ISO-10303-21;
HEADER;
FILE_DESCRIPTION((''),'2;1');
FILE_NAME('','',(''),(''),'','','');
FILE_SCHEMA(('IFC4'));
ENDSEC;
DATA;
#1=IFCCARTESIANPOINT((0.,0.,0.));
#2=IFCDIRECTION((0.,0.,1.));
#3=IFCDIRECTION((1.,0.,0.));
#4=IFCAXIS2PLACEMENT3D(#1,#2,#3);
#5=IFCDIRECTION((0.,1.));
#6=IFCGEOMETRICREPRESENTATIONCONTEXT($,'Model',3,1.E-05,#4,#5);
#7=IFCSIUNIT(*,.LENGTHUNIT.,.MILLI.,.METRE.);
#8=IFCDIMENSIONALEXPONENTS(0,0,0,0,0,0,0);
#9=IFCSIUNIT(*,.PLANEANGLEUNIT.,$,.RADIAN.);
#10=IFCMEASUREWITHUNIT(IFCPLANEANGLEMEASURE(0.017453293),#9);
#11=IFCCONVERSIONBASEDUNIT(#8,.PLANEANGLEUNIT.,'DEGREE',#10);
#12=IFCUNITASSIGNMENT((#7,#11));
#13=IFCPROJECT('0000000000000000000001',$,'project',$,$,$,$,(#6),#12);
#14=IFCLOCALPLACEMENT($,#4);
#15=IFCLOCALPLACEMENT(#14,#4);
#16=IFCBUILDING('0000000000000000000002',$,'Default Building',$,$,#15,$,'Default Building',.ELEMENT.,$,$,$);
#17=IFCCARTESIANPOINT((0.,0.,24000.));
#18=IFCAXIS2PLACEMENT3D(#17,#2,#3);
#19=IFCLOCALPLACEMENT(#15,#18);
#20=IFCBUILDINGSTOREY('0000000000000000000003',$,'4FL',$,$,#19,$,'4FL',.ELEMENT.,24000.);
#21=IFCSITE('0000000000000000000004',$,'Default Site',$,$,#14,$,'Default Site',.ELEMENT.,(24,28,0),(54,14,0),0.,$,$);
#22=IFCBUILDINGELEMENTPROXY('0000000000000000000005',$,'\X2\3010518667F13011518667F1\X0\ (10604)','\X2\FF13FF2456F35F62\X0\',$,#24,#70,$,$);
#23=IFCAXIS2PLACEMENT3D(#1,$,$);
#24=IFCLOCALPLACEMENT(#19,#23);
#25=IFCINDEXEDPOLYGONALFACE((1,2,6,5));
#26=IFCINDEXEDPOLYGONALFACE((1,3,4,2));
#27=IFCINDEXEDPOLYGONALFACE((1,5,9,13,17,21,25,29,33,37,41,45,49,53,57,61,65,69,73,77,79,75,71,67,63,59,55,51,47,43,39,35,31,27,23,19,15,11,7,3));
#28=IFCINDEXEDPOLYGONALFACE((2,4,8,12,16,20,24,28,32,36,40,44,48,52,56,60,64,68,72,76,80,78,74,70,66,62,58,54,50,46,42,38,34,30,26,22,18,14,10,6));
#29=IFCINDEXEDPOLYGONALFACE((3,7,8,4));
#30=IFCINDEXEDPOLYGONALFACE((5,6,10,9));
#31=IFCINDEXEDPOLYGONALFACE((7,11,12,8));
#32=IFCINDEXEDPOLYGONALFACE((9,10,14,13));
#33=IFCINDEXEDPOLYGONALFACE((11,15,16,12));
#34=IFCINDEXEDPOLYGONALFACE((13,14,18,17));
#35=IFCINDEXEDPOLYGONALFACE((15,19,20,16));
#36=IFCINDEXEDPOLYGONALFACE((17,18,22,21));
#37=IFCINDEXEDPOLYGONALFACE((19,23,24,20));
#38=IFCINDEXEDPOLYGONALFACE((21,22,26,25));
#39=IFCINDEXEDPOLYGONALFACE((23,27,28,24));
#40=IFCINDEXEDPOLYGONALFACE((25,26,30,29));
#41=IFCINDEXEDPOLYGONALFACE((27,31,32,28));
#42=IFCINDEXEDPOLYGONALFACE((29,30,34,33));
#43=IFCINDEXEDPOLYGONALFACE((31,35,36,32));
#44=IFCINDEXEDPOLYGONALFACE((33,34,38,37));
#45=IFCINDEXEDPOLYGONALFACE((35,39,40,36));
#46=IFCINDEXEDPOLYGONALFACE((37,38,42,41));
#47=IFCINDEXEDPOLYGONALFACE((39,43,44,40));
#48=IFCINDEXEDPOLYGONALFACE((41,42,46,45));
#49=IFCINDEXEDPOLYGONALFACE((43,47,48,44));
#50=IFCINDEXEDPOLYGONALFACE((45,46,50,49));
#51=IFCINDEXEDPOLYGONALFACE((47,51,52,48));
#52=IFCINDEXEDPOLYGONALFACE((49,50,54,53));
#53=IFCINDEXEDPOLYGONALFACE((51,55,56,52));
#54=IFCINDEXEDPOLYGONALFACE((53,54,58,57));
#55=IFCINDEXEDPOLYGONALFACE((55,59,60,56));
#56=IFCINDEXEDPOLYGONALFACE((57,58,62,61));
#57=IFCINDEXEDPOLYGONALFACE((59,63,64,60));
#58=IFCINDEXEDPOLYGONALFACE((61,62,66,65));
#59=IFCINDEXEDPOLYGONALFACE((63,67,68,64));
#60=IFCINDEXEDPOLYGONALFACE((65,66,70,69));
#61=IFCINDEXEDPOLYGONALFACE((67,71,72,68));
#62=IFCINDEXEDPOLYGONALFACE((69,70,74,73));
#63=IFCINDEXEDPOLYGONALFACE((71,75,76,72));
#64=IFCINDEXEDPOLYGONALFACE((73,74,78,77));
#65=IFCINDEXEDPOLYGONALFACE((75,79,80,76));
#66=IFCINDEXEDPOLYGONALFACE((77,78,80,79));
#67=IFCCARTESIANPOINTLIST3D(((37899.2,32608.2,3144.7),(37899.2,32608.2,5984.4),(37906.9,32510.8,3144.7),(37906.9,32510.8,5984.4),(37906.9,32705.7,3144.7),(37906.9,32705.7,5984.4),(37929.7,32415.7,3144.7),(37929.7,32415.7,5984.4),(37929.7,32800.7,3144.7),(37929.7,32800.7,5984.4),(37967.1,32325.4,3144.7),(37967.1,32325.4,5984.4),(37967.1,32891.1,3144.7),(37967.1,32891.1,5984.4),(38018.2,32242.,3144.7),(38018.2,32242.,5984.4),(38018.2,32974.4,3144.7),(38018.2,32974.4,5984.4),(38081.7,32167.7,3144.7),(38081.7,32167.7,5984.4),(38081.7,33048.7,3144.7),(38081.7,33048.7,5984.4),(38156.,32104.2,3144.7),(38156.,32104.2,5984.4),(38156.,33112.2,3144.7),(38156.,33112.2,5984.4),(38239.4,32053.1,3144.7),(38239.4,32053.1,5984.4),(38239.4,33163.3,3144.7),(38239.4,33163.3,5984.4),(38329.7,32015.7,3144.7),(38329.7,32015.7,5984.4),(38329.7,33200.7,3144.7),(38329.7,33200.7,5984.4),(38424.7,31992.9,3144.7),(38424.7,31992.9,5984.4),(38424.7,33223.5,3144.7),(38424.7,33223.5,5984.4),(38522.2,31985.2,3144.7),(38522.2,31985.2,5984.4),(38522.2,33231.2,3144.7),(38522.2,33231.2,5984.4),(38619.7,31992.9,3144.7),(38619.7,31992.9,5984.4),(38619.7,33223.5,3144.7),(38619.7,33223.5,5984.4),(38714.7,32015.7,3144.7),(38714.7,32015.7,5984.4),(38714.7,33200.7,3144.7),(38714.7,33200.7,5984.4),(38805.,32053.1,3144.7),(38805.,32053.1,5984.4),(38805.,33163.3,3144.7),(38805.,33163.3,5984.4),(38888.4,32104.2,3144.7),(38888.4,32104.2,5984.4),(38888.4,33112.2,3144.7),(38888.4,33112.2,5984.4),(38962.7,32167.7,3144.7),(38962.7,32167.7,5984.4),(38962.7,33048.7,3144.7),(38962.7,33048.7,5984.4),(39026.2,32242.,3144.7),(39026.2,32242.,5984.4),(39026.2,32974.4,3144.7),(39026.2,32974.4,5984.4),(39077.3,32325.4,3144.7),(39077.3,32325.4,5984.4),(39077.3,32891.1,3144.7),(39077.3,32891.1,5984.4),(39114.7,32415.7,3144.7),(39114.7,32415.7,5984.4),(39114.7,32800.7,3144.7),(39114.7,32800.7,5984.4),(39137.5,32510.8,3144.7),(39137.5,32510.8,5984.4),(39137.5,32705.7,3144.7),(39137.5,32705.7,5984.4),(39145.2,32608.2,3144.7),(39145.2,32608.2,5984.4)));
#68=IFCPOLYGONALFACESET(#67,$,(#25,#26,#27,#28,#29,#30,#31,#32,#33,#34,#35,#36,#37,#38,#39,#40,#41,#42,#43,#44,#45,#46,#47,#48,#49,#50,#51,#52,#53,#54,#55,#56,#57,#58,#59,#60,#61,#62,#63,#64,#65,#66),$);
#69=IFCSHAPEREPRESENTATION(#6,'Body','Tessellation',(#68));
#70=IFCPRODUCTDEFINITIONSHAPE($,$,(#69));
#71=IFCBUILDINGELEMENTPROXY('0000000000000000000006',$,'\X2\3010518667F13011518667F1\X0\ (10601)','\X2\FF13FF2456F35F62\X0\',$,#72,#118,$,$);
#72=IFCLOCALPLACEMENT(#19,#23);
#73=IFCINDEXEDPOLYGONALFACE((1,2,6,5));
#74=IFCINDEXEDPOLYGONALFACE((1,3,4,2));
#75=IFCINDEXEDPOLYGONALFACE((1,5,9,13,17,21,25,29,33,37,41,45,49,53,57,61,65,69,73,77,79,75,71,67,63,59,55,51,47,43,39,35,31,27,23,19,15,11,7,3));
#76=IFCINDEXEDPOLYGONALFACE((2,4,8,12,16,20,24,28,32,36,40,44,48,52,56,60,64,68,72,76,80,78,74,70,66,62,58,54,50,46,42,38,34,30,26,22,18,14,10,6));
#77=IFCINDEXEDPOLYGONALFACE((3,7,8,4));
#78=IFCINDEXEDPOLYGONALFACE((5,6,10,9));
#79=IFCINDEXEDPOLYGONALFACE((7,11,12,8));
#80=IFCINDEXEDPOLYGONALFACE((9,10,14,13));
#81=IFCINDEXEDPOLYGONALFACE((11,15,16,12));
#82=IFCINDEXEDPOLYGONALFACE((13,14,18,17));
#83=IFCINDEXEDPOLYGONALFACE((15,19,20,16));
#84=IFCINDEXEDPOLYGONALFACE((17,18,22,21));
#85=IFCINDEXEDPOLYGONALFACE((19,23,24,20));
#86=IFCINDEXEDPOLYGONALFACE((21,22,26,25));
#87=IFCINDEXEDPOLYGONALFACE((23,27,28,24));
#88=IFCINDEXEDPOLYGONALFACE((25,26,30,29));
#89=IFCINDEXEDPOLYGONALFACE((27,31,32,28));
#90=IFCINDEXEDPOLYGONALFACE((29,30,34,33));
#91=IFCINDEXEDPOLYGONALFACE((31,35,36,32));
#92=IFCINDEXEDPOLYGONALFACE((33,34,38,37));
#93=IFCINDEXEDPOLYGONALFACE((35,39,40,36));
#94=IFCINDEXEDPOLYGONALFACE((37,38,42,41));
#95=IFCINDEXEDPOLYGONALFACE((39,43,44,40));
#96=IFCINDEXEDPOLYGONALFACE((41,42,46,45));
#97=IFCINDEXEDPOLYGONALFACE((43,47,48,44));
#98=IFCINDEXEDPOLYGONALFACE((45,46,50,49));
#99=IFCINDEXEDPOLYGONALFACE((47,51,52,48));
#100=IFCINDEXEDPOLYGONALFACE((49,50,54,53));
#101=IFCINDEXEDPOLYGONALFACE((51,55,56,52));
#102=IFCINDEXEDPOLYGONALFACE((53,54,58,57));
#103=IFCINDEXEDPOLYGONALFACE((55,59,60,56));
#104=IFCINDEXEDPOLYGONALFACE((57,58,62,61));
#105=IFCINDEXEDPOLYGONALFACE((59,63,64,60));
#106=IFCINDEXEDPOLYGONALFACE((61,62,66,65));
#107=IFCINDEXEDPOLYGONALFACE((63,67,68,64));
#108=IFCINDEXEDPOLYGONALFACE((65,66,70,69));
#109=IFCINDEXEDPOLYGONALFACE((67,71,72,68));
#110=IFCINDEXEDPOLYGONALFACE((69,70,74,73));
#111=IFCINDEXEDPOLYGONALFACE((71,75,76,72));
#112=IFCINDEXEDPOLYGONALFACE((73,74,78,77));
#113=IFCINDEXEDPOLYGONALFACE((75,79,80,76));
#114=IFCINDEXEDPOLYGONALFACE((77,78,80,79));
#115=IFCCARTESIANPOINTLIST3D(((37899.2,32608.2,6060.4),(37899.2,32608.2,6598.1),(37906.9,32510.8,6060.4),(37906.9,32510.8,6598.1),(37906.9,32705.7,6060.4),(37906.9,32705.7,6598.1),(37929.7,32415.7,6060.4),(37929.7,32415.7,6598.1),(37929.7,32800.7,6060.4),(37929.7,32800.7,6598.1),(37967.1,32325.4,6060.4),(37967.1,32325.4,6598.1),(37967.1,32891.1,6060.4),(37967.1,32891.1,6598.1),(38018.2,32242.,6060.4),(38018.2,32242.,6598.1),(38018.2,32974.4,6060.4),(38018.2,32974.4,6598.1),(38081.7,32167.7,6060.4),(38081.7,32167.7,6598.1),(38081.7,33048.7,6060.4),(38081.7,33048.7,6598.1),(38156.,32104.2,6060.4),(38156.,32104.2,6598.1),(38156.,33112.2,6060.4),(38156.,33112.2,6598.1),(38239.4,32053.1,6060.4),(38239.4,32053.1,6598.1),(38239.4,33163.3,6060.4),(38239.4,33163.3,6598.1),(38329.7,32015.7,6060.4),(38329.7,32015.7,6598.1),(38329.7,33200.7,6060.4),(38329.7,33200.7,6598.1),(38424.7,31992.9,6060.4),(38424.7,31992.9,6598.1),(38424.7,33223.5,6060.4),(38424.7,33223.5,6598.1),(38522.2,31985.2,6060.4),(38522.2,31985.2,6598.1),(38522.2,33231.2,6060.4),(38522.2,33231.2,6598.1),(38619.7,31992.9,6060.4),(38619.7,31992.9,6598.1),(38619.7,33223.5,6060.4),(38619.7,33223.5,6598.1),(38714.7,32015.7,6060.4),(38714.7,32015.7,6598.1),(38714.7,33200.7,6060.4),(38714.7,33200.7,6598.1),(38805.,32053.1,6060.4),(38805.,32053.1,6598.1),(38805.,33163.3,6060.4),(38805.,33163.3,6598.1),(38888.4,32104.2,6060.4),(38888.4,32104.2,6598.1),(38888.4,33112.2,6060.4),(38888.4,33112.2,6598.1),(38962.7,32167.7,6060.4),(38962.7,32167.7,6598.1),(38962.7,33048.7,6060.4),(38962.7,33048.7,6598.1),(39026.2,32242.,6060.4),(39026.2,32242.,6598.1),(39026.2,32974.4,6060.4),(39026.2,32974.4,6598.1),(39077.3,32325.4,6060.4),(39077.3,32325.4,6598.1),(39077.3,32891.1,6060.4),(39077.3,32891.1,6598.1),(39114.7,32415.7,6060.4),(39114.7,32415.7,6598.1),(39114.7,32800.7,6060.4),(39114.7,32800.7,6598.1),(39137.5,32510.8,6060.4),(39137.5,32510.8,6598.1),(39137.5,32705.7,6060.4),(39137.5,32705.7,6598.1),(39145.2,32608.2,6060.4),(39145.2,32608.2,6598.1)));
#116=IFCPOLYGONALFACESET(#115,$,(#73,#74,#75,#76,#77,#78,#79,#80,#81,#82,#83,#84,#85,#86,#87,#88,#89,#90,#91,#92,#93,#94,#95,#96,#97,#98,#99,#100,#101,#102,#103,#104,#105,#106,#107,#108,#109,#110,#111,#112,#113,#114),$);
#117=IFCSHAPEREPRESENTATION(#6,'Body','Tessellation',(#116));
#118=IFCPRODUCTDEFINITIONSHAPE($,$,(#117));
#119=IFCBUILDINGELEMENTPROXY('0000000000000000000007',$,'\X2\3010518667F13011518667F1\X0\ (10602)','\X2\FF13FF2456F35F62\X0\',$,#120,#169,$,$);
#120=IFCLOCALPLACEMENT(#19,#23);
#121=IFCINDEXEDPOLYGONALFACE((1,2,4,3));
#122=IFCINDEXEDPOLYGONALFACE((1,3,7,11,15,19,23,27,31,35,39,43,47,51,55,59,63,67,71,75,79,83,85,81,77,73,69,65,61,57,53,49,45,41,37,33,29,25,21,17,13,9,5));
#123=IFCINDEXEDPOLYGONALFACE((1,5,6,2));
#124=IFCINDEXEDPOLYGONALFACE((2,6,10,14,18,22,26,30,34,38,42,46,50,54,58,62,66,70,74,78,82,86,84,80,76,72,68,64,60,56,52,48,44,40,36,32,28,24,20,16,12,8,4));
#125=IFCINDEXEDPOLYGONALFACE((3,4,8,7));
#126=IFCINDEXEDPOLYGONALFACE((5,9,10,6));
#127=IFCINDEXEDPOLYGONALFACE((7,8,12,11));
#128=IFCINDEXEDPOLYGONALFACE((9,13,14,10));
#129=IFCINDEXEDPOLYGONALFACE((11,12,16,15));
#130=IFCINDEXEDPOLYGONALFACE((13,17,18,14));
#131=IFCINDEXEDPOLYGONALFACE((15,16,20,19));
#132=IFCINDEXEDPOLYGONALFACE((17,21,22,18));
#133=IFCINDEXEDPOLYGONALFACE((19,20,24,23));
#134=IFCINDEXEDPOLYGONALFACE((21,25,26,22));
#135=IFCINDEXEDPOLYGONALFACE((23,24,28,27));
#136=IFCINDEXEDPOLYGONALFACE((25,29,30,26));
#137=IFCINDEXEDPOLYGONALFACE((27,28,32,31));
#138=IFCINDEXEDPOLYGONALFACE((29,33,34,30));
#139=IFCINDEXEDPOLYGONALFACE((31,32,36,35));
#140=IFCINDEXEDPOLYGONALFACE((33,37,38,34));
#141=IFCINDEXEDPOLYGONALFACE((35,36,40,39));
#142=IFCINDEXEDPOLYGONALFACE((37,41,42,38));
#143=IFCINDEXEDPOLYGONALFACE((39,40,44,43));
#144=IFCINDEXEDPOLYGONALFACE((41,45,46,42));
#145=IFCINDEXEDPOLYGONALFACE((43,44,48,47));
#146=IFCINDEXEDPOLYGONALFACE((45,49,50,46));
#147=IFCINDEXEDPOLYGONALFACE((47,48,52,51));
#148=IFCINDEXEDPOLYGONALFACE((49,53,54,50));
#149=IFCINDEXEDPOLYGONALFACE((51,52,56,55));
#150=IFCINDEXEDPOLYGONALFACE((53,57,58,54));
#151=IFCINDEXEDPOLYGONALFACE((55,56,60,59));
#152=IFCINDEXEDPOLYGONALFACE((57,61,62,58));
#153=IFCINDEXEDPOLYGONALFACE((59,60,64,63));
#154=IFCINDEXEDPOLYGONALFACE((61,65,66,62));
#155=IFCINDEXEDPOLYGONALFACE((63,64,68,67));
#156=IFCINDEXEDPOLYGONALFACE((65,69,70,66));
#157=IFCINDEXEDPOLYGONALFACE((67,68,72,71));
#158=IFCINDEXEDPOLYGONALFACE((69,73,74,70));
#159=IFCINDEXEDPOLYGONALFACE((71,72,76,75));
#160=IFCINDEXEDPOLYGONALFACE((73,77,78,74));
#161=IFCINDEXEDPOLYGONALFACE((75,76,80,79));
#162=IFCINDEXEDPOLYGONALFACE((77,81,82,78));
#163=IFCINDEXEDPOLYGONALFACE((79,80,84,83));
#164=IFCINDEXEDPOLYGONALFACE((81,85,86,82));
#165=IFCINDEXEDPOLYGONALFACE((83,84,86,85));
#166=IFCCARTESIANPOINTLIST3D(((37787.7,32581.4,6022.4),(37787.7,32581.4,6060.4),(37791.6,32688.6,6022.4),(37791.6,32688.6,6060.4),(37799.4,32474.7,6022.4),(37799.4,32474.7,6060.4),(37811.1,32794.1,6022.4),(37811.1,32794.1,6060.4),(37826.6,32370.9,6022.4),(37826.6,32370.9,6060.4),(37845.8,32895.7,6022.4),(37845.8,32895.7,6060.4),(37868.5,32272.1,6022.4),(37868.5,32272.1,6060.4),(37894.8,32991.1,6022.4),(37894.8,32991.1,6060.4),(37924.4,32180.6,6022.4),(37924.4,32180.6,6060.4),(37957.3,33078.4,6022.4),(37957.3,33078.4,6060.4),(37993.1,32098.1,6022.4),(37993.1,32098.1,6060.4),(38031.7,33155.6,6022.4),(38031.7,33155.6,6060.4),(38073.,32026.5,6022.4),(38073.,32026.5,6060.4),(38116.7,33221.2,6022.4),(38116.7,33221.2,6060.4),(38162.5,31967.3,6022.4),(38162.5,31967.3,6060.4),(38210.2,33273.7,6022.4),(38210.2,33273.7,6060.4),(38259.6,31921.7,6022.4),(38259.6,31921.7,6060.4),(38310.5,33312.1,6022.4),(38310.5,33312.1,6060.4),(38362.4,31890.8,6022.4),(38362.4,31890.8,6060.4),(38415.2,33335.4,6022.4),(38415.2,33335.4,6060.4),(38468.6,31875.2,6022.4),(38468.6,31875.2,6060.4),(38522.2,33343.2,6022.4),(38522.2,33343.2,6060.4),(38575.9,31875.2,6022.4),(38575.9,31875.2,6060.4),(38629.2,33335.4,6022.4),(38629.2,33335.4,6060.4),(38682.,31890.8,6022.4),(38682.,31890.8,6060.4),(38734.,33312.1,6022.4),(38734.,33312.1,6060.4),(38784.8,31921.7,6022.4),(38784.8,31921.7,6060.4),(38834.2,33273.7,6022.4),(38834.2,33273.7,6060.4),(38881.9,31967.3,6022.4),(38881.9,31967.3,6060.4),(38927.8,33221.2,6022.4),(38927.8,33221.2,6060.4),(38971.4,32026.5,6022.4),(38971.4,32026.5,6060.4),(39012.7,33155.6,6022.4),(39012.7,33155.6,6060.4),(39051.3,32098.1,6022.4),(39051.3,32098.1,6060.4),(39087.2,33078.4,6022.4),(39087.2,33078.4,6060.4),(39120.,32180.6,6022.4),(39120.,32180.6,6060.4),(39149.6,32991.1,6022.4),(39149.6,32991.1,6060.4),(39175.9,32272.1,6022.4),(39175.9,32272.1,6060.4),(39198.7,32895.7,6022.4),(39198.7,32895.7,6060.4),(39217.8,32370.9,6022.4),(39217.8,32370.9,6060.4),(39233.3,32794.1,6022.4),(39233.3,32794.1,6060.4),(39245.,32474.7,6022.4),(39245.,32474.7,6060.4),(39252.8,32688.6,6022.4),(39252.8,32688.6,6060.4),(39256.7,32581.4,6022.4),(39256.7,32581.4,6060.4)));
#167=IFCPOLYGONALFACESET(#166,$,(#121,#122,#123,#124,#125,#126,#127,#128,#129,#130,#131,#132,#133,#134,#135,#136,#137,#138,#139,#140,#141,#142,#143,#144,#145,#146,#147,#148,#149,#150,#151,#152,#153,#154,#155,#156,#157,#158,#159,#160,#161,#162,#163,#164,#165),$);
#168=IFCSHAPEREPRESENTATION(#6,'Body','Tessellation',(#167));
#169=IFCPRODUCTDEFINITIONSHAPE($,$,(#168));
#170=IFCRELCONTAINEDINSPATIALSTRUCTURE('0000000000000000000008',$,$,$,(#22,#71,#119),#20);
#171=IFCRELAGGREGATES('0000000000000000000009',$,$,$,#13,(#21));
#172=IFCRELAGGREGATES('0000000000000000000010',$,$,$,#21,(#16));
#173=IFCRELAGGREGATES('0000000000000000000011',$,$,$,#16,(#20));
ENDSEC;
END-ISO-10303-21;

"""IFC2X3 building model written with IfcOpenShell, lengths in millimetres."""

from ifc_helpers import new_model, entity, si_unit, converted_unit, direction, frame, origin_with_axes, origin_2d_with_axis, place, context, project, spatial, circle, extrude, source, transform, mapped, element, save


model = new_model("IFC2X3")

# Units and contexts
model_context = context("Model", 3, precision=1e-05, world=origin_with_axes(), true_north=direction((0.0, 1.0)))
ifc_project = project(units=[si_unit("LENGTHUNIT", "METRE", prefix="MILLI"), converted_unit("PLANEANGLEUNIT", "DEGREE", entity("IfcPlaneAngleMeasure", 0.017453293), si_unit("PLANEANGLEUNIT", "RADIAN"), dimensions=[0, 0, 0, 0, 0, 0, 0])], contexts=[model_context])

# Site, building, storey
site_placement = place(None, origin_with_axes())
site = spatial("IfcSite", under=ifc_project, at=site_placement, Name="Default Site", LongName="Default Site", CompositionType="ELEMENT", RefLatitude=(24, 28, 0), RefLongitude=(54, 14, 0), RefElevation=0.0)
building_placement = place(site_placement, origin_with_axes())
building = spatial("IfcBuilding", under=site, at=building_placement, Name="Default Building", LongName="Default Building", CompositionType="ELEMENT")
storey_placement = place(building_placement, frame((0.0, 0.0, 24000.0), z_axis=(0.0, 0.0, 1.0), x_axis=(1.0, 0.0, 0.0)))
storey = spatial("IfcBuildingStorey", under=building, at=storey_placement, Name="4FL", LongName="4FL", CompositionType="ELEMENT", Elevation=24000.0)

# Building element proxies
shared_shape_1 = source(origin_with_axes(), model_context, "Body", "SweptSolid", [
    extrude(circle(Radius=623.0, at=origin_2d_with_axis()), frame((0.0, 0.0, 0.0), z_axis=(0.0, 0.0, 1.0), x_axis=(1.0, 0.0, 0.0)), (0.0, 0.0, 1.0), 2839.7),
])
proxy_1_placement = place(storey_placement, frame((38522.2, 32608.2, 5984.4), z_axis=(0.0, 0.0, -1.0), x_axis=(0.0, 1.0, 0.0)))
element("IfcBuildingElementProxy", 1, at=proxy_1_placement, inside=storey, Name="【円柱】円柱 (10604)", Description="３Ｄ図形", context=model_context, shape_type="MappedRepresentation", body=[
    mapped(shared_shape_1, transform((0.0, 0.0, 0.0))),
])
shared_shape_2 = source(origin_with_axes(), model_context, "Body", "SweptSolid", [
    extrude(circle(Radius=623.0, at=origin_2d_with_axis()), frame((0.0, 0.0, 0.0), z_axis=(0.0, 0.0, 1.0), x_axis=(1.0, 0.0, 0.0)), (0.0, 0.0, 1.0), 537.6),
])
proxy_2_placement = place(storey_placement, frame((38522.2, 32608.2, 6598.1), z_axis=(0.0, 0.0, -1.0), x_axis=(0.0, 1.0, 0.0)))
element("IfcBuildingElementProxy", 2, at=proxy_2_placement, inside=storey, Name="【円柱】円柱 (10601)", Description="３Ｄ図形", context=model_context, shape_type="MappedRepresentation", body=[
    mapped(shared_shape_2, transform((0.0, 0.0, 0.0))),
])
shared_shape_3 = source(origin_with_axes(), model_context, "Body", "SweptSolid", [
    extrude(circle(Radius=735.0, at=origin_2d_with_axis()), frame((0.0, 0.0, 0.0), z_axis=(0.0, 0.0, 1.0), x_axis=(1.0, 0.0, 0.0)), (0.0, 0.0, 1.0), 38.0),
])
proxy_3_placement = place(storey_placement, frame((38522.2, 32608.2, 6022.4), z_axis=(0.0, 0.0, 1.0), x_axis=(0.0, 1.0, 0.0)))
element("IfcBuildingElementProxy", 3, at=proxy_3_placement, inside=storey, Name="【円柱】円柱 (10602)", Description="３Ｄ図形", context=model_context, shape_type="MappedRepresentation", body=[
    mapped(shared_shape_3, transform((0.0, 0.0, 0.0))),
])

save(model, "model.ifc")
